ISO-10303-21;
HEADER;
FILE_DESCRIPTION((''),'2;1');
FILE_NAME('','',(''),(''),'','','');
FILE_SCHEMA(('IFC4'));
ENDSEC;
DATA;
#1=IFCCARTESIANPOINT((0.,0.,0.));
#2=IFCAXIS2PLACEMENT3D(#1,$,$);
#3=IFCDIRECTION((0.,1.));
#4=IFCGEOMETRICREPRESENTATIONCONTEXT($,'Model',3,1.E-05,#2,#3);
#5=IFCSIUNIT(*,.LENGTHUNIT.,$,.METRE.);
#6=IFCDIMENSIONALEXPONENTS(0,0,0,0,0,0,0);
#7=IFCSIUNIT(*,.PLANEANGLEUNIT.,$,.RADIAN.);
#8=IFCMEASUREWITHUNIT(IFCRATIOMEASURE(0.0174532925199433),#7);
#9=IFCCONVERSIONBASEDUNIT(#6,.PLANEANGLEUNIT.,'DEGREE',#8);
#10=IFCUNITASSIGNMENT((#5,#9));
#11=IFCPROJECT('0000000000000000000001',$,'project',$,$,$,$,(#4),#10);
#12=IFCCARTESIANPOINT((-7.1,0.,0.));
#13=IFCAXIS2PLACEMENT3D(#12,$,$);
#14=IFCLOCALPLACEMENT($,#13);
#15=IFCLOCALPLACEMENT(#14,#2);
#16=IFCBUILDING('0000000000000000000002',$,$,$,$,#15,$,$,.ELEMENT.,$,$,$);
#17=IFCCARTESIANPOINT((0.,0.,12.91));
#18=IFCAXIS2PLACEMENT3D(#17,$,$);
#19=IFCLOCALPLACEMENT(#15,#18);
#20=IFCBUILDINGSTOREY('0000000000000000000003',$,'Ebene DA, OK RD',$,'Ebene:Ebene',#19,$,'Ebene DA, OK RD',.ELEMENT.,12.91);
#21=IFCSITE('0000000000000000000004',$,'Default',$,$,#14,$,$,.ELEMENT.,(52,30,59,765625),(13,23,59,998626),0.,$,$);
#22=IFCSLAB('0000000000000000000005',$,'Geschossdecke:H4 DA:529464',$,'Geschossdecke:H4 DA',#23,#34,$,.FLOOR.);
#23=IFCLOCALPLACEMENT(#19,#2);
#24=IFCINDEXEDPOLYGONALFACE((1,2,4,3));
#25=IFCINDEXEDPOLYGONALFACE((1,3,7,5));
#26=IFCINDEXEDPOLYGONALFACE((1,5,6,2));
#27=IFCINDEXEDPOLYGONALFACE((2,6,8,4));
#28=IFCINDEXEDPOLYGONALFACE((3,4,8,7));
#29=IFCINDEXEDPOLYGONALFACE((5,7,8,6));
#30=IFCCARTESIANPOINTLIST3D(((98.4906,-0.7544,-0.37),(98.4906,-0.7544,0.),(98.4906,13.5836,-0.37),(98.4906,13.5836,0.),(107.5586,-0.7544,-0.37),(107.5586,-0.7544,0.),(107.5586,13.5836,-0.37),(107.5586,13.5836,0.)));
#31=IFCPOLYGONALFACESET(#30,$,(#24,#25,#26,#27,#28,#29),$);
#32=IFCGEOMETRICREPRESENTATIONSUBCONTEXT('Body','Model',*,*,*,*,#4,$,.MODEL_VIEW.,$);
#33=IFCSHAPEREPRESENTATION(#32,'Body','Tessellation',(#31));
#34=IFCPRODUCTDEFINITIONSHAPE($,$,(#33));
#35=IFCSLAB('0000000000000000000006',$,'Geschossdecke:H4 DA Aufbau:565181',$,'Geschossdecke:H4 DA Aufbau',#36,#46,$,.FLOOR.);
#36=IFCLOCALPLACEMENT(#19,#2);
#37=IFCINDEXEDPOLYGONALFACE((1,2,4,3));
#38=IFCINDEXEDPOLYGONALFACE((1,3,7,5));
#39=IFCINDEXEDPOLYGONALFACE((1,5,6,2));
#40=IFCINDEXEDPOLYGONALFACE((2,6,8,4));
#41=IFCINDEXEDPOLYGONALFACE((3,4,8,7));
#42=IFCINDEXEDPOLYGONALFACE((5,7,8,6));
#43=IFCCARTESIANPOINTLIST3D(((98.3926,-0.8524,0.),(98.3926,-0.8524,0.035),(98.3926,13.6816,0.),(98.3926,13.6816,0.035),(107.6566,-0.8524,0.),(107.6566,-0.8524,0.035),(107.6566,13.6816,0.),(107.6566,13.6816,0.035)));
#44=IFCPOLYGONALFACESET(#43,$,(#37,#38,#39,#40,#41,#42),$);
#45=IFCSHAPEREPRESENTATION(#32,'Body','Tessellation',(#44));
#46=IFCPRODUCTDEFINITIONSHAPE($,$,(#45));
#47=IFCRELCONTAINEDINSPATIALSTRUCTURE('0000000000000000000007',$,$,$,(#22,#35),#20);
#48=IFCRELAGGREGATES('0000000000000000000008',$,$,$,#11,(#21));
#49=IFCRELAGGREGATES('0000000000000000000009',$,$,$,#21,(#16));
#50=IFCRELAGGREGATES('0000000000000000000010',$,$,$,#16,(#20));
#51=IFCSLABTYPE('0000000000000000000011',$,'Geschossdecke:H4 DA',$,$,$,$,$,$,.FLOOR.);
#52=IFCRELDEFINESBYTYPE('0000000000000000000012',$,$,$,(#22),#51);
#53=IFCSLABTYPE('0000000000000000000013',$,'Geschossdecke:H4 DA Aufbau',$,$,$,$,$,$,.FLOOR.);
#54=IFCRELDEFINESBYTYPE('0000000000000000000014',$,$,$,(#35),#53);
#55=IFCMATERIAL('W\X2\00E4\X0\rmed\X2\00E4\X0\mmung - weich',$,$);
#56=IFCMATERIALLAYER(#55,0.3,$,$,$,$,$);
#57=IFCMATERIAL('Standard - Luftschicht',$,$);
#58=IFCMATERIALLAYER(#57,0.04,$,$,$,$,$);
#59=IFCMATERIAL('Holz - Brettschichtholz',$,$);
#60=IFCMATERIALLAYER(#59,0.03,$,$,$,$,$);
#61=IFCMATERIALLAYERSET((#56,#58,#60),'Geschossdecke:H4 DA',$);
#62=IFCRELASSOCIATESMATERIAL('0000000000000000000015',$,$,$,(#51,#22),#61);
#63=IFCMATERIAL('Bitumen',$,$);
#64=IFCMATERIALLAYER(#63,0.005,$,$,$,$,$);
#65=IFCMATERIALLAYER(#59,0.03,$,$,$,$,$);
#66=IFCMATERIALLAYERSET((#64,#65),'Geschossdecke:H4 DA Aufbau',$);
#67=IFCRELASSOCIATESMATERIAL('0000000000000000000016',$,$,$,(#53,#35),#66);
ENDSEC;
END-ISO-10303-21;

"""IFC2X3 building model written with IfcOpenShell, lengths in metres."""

from ifc_helpers import new_model, entity, si_unit, converted_unit, direction, frame, frame_2d, origin, origin_2d_with_axis, place, context, subcontext, project, spatial, rectangle, extrude, material, layer, layer_set, layer_usage, type_object, element, save


model = new_model("IFC2X3")

# Units and contexts
model_context = context("Model", 3, precision=1e-05, world=origin(), true_north=direction((0.0, 1.0)))
body_context = subcontext(model_context, "Body", "Model", "MODEL_VIEW")
ifc_project = project(units=[si_unit("LENGTHUNIT", "METRE"), converted_unit("PLANEANGLEUNIT", "DEGREE", entity("IfcRatioMeasure", 0.0174532925199433), si_unit("PLANEANGLEUNIT", "RADIAN"), dimensions=[0, 0, 0, 0, 0, 0, 0])], contexts=[model_context])

# Site, building, storey
site_placement = place(None, frame((-7.1, 0.0, 0.0)))
site = spatial("IfcSite", under=ifc_project, at=site_placement, Name="Default", CompositionType="ELEMENT", RefLatitude=(52, 30, 59, 765625), RefLongitude=(13, 23, 59, 998626), RefElevation=0.0)
building_placement = place(site_placement, origin())
building = spatial("IfcBuilding", under=site, at=building_placement, CompositionType="ELEMENT")
storey_placement = place(building_placement, frame((0.0, 0.0, 12.91)))
storey = spatial("IfcBuildingStorey", under=building, at=storey_placement, Name="Ebene DA, OK RD", ObjectType="Ebene:Ebene", LongName="Ebene DA, OK RD", CompositionType="ELEMENT", Elevation=12.91)

# Slabs
ifc_material_1 = material(Name="Wärmedämmung - weich")
ifc_layer_1 = layer(ifc_material_1, 0.3)
ifc_material_2 = material(Name="Standard - Luftschicht")
ifc_layer_2 = layer(ifc_material_2, 0.04)
ifc_material_3 = material(Name="Holz - Brettschichtholz")
ifc_layer_3 = layer(ifc_material_3, 0.03)
ifc_layer_set_1 = layer_set([ifc_layer_1, ifc_layer_2, ifc_layer_3], Name="Geschossdecke:H4 DA")
ifc_layer_usage_1 = layer_usage(ifc_layer_set_1, "AXIS3", "POSITIVE", 0.0)
slab_type_1 = type_object("IfcSlabType", Name="Geschossdecke:H4 DA", PredefinedType="FLOOR", material=ifc_layer_set_1)
slab_1_placement = place(storey_placement, origin())
element("IfcSlab", 1, at=slab_1_placement, inside=storey, type_object=slab_type_1, material=ifc_layer_usage_1, Name="Geschossdecke:H4 DA:529464", ObjectType="Geschossdecke:H4 DA", PredefinedType="FLOOR", context=body_context, shape_type="SweptSolid", body=[
    extrude(rectangle(XDim=14.338, YDim=9.068, at=frame_2d((0.0, 0.0), x_axis=(1.0, 0.0))), frame((103.0246, 6.4146, 0.0), z_axis=(0.0, 0.0, -1.0), x_axis=(0.0, 1.0, 0.0)), (0.0, 0.0, 1.0), 0.37),
])
ifc_material_4 = material(Name="Bitumen")
ifc_layer_4 = layer(ifc_material_4, 0.005)
ifc_layer_5 = layer(ifc_material_3, 0.03)
ifc_layer_set_2 = layer_set([ifc_layer_4, ifc_layer_5], Name="Geschossdecke:H4 DA Aufbau")
ifc_layer_usage_2 = layer_usage(ifc_layer_set_2, "AXIS3", "POSITIVE", 0.0)
slab_type_2 = type_object("IfcSlabType", Name="Geschossdecke:H4 DA Aufbau", PredefinedType="FLOOR", material=ifc_layer_set_2)
slab_2_placement = place(storey_placement, origin())
element("IfcSlab", 2, at=slab_2_placement, inside=storey, type_object=slab_type_2, material=ifc_layer_usage_2, Name="Geschossdecke:H4 DA Aufbau:565181", ObjectType="Geschossdecke:H4 DA Aufbau", PredefinedType="FLOOR", context=body_context, shape_type="SweptSolid", body=[
    extrude(rectangle(XDim=14.534, YDim=9.264, at=origin_2d_with_axis()), frame((103.0246, 6.4146, 0.035), z_axis=(0.0, 0.0, -1.0), x_axis=(0.0, 1.0, 0.0)), (0.0, 0.0, 1.0), 0.035),
])

save(model, "model.ifc")
